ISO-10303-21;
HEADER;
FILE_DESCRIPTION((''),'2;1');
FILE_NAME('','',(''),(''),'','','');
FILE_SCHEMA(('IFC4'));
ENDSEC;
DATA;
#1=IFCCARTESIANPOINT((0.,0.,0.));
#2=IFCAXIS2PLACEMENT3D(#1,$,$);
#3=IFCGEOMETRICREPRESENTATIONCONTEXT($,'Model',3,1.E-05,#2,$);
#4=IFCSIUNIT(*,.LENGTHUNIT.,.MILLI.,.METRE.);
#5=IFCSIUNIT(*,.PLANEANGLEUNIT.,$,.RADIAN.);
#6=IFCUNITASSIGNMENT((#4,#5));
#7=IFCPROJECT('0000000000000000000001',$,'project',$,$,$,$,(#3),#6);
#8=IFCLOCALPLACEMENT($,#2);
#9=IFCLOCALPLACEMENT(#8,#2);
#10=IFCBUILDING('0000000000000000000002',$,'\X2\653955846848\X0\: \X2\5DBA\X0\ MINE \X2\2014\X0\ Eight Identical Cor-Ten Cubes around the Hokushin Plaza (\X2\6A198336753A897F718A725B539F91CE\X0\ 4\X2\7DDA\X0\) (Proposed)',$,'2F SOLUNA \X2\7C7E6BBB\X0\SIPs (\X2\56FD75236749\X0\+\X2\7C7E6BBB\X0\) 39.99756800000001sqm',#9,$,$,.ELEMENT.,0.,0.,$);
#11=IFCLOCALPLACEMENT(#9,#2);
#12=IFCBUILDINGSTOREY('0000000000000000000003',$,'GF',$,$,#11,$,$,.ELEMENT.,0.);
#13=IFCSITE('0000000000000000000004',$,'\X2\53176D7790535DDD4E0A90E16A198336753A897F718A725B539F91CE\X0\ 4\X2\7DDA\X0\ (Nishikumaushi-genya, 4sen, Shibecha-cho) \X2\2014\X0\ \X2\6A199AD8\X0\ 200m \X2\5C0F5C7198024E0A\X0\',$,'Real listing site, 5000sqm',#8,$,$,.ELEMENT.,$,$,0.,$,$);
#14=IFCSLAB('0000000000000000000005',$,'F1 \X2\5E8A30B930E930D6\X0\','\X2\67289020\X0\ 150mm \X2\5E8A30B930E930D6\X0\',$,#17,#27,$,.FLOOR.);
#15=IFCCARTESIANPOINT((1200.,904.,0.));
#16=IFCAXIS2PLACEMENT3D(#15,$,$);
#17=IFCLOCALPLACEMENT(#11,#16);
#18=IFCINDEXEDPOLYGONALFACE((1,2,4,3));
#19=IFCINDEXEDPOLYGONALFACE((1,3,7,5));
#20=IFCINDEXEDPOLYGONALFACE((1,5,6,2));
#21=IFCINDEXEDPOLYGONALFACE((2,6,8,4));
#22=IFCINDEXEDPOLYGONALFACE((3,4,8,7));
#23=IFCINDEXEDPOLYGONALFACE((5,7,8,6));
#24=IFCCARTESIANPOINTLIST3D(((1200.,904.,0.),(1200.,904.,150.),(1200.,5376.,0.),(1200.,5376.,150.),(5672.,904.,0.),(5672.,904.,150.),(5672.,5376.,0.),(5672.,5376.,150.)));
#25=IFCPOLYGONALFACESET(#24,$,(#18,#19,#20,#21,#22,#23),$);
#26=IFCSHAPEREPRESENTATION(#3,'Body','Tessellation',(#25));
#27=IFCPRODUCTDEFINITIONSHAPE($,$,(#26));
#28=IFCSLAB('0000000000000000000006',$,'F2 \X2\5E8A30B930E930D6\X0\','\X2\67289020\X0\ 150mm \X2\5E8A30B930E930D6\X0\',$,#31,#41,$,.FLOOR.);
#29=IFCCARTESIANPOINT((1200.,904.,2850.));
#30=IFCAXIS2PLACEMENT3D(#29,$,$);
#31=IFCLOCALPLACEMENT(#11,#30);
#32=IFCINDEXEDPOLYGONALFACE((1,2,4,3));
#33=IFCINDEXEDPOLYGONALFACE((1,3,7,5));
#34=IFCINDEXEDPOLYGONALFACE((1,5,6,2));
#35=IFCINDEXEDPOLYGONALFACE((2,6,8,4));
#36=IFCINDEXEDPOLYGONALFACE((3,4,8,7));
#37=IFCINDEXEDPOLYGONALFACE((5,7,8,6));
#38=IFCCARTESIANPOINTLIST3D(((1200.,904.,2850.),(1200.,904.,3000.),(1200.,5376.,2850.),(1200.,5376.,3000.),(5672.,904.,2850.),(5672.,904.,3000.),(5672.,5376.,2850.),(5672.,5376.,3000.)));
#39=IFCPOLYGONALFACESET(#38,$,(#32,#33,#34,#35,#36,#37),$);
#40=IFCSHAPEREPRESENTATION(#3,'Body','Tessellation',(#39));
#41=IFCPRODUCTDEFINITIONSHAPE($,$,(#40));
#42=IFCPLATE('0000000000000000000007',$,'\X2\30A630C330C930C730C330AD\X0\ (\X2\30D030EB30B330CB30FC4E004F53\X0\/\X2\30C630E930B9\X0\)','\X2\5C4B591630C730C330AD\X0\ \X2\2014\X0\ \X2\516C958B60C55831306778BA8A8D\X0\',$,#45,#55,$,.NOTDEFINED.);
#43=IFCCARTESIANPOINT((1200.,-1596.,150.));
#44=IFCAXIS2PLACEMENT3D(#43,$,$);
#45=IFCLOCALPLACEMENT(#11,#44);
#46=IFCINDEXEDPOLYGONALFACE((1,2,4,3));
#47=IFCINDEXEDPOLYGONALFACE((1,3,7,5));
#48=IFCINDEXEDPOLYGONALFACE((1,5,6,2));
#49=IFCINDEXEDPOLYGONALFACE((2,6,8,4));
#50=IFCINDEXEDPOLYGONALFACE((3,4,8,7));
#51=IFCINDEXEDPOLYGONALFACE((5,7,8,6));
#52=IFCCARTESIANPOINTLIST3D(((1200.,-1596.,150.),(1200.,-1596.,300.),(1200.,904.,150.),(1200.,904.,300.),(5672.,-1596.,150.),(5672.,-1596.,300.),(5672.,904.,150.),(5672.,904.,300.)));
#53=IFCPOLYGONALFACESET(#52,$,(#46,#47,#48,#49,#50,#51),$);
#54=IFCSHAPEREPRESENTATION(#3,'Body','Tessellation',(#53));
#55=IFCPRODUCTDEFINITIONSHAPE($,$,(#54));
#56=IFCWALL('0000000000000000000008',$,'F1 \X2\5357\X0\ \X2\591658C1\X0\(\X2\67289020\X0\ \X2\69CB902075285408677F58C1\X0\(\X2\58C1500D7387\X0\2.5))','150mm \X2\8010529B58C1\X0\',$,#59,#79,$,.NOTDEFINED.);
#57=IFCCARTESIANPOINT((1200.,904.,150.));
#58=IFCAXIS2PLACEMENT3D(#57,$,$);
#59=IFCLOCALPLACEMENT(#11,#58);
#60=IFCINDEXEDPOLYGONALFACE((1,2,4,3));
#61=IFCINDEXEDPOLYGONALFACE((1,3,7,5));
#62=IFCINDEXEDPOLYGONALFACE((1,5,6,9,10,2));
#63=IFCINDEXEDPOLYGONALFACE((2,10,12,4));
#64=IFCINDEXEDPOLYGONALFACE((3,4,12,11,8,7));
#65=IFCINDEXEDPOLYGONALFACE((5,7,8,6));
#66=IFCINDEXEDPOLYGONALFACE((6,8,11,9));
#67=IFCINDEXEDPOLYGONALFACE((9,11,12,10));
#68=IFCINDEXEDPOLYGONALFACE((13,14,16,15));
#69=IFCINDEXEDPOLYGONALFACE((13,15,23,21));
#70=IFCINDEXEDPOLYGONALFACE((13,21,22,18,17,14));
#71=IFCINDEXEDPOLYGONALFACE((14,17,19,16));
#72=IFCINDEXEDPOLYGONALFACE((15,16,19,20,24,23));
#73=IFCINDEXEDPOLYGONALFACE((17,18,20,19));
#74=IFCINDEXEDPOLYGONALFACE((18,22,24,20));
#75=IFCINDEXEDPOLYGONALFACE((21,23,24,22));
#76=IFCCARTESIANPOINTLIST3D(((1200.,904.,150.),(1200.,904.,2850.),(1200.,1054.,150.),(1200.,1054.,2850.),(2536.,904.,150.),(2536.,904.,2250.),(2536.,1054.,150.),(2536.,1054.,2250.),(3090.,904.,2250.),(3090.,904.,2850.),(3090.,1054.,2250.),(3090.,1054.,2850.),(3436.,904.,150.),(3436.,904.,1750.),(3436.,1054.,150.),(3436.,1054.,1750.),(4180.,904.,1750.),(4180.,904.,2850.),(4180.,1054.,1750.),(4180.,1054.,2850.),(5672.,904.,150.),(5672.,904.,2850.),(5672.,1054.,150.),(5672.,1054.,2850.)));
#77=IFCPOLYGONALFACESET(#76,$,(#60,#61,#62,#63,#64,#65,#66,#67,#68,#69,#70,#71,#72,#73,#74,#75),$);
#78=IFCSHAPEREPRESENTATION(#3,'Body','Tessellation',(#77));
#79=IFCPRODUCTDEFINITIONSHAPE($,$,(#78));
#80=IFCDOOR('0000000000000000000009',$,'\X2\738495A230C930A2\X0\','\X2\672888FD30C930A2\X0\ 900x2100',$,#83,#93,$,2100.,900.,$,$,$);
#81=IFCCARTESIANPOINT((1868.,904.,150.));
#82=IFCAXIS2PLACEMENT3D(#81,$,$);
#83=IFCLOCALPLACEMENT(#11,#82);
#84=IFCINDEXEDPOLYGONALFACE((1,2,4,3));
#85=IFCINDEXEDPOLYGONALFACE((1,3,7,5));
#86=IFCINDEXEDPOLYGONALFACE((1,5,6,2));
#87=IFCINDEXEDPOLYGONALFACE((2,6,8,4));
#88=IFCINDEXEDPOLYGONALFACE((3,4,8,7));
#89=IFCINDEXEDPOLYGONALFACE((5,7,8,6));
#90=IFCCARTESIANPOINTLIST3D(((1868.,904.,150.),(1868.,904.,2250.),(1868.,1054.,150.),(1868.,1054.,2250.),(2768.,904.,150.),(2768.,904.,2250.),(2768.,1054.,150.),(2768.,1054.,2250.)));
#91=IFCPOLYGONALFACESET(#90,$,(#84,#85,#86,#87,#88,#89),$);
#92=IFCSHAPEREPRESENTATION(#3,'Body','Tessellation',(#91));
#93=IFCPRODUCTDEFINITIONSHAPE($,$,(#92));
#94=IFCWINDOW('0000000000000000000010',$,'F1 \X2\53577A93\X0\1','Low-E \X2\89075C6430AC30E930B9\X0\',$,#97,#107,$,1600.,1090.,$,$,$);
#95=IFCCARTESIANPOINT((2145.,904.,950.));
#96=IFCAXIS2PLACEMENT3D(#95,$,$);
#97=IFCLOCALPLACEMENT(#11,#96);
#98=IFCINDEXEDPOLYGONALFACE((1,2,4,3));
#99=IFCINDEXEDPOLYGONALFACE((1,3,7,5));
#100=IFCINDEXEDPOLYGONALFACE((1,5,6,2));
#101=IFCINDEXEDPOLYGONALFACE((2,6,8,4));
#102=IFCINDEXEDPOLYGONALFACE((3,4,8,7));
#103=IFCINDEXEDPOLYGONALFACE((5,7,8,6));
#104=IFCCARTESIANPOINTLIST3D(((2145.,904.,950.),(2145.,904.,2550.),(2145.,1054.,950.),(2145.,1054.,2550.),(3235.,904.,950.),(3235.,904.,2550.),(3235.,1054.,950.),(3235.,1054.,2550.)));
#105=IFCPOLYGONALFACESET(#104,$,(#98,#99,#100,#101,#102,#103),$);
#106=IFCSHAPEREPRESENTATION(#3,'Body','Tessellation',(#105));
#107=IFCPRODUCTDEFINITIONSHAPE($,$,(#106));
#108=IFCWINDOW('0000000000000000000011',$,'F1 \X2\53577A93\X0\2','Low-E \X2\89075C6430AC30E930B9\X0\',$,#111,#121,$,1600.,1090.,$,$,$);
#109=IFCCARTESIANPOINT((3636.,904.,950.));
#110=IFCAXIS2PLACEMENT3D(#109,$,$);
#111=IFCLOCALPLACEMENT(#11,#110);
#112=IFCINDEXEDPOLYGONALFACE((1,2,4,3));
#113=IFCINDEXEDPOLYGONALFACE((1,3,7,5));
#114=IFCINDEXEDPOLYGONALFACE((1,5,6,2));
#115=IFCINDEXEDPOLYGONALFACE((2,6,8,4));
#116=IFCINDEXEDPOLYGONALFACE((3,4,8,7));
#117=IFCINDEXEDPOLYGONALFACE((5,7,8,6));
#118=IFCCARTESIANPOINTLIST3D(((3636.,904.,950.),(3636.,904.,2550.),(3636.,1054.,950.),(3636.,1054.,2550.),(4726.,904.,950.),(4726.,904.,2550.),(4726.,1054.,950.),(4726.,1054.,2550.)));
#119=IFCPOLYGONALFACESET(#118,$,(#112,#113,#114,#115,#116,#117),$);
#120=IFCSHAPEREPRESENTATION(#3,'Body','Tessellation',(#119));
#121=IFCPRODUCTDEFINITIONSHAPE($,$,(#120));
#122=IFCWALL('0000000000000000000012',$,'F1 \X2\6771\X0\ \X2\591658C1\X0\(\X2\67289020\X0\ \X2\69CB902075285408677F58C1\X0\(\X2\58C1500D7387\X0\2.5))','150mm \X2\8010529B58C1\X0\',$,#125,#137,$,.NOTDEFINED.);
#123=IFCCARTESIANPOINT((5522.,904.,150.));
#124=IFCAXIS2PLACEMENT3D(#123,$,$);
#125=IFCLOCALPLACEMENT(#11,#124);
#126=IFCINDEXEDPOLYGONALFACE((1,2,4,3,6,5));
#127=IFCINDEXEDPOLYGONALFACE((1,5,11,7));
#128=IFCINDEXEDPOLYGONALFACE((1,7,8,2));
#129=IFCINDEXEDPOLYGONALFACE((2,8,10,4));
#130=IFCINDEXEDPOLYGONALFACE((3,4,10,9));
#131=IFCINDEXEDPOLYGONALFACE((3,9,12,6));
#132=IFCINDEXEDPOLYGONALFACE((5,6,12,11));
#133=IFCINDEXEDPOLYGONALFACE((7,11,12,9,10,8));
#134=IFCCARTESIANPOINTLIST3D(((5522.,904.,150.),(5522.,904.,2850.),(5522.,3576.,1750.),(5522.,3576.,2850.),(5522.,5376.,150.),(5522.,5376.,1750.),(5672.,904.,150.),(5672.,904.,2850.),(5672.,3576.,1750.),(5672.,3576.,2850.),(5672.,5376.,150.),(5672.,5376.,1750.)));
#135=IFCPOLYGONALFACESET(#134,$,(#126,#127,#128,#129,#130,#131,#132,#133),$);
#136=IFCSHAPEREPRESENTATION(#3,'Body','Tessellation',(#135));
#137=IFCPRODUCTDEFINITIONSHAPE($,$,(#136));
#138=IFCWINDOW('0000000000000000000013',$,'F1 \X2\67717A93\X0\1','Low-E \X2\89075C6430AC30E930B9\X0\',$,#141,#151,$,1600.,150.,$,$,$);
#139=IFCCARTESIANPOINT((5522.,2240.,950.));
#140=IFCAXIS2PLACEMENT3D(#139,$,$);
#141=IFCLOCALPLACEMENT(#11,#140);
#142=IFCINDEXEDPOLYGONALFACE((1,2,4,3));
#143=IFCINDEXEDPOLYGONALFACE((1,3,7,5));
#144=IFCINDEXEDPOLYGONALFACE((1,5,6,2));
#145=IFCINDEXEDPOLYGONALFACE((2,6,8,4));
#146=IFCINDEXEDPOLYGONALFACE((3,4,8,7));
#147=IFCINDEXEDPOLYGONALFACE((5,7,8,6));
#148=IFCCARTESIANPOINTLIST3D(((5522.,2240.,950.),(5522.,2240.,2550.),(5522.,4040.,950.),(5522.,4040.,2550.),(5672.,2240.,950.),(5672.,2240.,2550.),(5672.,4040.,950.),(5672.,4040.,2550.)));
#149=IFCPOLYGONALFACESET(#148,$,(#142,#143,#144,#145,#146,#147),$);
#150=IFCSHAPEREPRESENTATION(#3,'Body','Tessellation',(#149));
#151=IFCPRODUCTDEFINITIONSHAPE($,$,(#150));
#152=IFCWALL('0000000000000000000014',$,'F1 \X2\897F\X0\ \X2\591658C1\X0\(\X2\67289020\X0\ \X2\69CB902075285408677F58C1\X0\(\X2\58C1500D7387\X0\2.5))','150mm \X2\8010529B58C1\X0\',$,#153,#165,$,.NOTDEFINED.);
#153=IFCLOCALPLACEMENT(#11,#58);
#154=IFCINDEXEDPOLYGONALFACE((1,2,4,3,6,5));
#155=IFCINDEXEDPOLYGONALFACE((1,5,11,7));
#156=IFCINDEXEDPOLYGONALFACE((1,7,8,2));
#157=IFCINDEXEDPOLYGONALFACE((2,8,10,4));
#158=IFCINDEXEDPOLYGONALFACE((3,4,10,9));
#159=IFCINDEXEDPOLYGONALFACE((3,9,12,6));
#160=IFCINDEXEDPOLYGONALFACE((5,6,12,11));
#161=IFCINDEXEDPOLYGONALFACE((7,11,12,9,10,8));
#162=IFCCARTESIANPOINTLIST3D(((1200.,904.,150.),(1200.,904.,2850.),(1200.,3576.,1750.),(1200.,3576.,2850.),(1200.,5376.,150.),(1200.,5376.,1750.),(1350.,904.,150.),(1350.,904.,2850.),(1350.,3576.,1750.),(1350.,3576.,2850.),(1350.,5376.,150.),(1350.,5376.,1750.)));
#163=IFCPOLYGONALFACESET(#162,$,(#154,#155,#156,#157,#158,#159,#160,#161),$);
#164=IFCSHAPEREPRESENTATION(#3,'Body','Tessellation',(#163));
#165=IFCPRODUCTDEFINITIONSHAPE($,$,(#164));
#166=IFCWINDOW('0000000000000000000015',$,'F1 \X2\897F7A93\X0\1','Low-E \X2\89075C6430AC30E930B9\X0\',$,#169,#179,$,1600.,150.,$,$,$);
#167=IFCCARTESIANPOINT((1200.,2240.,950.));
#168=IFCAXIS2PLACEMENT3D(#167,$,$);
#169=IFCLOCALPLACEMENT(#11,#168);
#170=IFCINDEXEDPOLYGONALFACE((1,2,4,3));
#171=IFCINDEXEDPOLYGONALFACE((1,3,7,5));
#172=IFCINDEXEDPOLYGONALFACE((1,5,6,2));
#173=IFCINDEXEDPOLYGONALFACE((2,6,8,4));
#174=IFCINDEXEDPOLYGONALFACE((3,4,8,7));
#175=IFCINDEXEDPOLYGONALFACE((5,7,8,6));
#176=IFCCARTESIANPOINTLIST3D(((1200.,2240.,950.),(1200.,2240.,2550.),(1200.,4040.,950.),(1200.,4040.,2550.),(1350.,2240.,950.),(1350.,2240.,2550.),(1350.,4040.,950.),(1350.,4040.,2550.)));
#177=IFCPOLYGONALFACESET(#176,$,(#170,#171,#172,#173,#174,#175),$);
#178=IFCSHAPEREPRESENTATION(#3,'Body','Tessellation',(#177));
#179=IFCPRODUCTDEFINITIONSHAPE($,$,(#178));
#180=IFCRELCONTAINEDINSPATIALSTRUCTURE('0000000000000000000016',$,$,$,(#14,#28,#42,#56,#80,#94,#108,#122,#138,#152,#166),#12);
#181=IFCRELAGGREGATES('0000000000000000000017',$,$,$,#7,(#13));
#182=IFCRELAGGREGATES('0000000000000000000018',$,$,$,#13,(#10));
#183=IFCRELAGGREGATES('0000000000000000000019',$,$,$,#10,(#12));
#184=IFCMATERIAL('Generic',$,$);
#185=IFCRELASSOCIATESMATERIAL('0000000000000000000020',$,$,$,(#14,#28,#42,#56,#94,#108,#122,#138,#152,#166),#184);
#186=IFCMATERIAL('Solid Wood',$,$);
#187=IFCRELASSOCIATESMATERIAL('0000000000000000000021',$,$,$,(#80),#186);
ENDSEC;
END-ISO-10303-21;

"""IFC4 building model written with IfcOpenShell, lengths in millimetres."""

from ifc_helpers import new_model, si_unit, frame, frame_2d, origin, place, context, project, spatial, rectangle, extrude, material, element, fill, save


model = new_model("IFC4")

# Units and contexts
model_context = context("Model", 3, precision=1e-05, world=origin())
ifc_project = project(units=[si_unit("LENGTHUNIT", "METRE", prefix="MILLI"), si_unit("PLANEANGLEUNIT", "RADIAN")], contexts=[model_context])

# Site, building, storey
site_placement = place(None, origin())
site = spatial("IfcSite", under=ifc_project, at=site_placement, Name="北海道川上郡標茶町西熊牛原野 4線 (Nishikumaushi-genya, 4sen, Shibecha-cho) — 標高 200m 小山頂上", ObjectType="Real listing site, 5000sqm", CompositionType="ELEMENT", RefElevation=0.0)
building_placement = place(site_placement, origin())
building = spatial("IfcBuilding", under=site, at=building_placement, Name="改善案: 嶺 MINE — Eight Identical Cor-Ten Cubes around the Hokushin Plaza (標茶町西熊牛原野 4線) (Proposed)", ObjectType="2F SOLUNA 籾殻SIPs (国産杉+籾殻) 39.99756800000001sqm", CompositionType="ELEMENT", ElevationOfRefHeight=0.0, ElevationOfTerrain=0.0)
storey_placement = place(building_placement, origin())
storey = spatial("IfcBuildingStorey", under=building, at=storey_placement, Name="GF", CompositionType="ELEMENT", Elevation=0.0)

# Slabs
ifc_material_1 = material(Name="Generic")
slab_1_placement = place(storey_placement, frame((1200.0, 904.0, 0.0)))
element("IfcSlab", 1, at=slab_1_placement, inside=storey, material=ifc_material_1, Name="F1 床スラブ", Description="木造 150mm 床スラブ", PredefinedType="FLOOR", context=model_context, shape_type="SweptSolid", body=[
    extrude(rectangle(XDim=4472.0, YDim=4472.0, at=frame_2d((2236.0, 2236.0))), frame((1200.0, 904.0, 0.0)), (0.0, 0.0, 1.0), 150.0),
])
slab_2_placement = place(storey_placement, frame((1200.0, 904.0, 2850.0)))
element("IfcSlab", 2, at=slab_2_placement, inside=storey, material=ifc_material_1, Name="F2 床スラブ", Description="木造 150mm 床スラブ", PredefinedType="FLOOR", context=model_context, shape_type="SweptSolid", body=[
    extrude(rectangle(XDim=4472.0, YDim=4472.0, at=frame_2d((2236.0, 2236.0))), frame((1200.0, 904.0, 2850.0)), (0.0, 0.0, 1.0), 150.0),
])

# Plate
plate_placement = place(storey_placement, frame((1200.0, -1596.0, 150.0)))
element("IfcPlate", 3, at=plate_placement, inside=storey, material=ifc_material_1, Name="ウッドデッキ (バルコニー一体/テラス)", Description="屋外デッキ — 公開情報で確認", PredefinedType="NOTDEFINED", context=model_context, shape_type="SweptSolid", body=[
    extrude(rectangle(XDim=4472.0, YDim=2500.0, at=frame_2d((2236.0, 1250.0))), frame((1200.0, -1596.0, 150.0)), (0.0, 0.0, 1.0), 150.0),
])

# Wall, openings, door, windows
wall_1_placement = place(storey_placement, frame((1200.0, 904.0, 150.0)))
wall_1 = element("IfcWall", 4, at=wall_1_placement, inside=storey, material=ifc_material_1, Name="F1 南 外壁(木造 構造用合板壁(壁倍率2.5))", Description="150mm 耐力壁", PredefinedType="NOTDEFINED", context=model_context, shape_type="SweptSolid", body=[
    extrude(rectangle(XDim=4472.0, YDim=150.0, at=frame_2d((2236.0, 75.0))), frame((1200.0, 904.0, 150.0)), (0.0, 0.0, 1.0), 2700.0),
])
opening_1_placement = place(storey_placement, frame((1868.0, 904.0, 150.0)))
opening_1 = element("IfcOpeningElement", 5, at=opening_1_placement, cuts=wall_1, PredefinedType="NOTDEFINED", context=model_context, shape_type="SweptSolid", body=[
    extrude(rectangle(XDim=900.0, YDim=150.0, at=frame_2d((450.0, 75.0))), frame((1868.0, 904.0, 150.0)), (0.0, 0.0, 1.0), 2100.0),
])
opening_2_placement = place(storey_placement, frame((2145.0, 904.0, 950.0)))
opening_2 = element("IfcOpeningElement", 6, at=opening_2_placement, cuts=wall_1, PredefinedType="NOTDEFINED", context=model_context, shape_type="SweptSolid", body=[
    extrude(rectangle(XDim=1090.0, YDim=150.0, at=frame_2d((545.0, 75.0))), frame((2145.0, 904.0, 950.0)), (0.0, 0.0, 1.0), 1600.0),
])
opening_3_placement = place(storey_placement, frame((3636.0, 904.0, 950.0)))
opening_3 = element("IfcOpeningElement", 7, at=opening_3_placement, cuts=wall_1, PredefinedType="NOTDEFINED", context=model_context, shape_type="SweptSolid", body=[
    extrude(rectangle(XDim=1090.0, YDim=150.0, at=frame_2d((545.0, 75.0))), frame((3636.0, 904.0, 950.0)), (0.0, 0.0, 1.0), 1600.0),
])
ifc_material_2 = material(Name="Solid Wood")
door_placement = place(storey_placement, frame((1868.0, 904.0, 150.0)))
door = element("IfcDoor", 8, at=door_placement, inside=storey, material=ifc_material_2, Name="玄関ドア", Description="木製ドア 900x2100", OverallHeight=2100.0, OverallWidth=900.0, context=model_context, shape_type="SweptSolid", body=[
    extrude(rectangle(XDim=900.0, YDim=150.0, at=frame_2d((450.0, 75.0))), frame((1868.0, 904.0, 150.0)), (0.0, 0.0, 1.0), 2100.0),
])
fill(opening_1, door)
window_1_placement = place(storey_placement, frame((2145.0, 904.0, 950.0)))
window_1 = element("IfcWindow", 9, at=window_1_placement, inside=storey, material=ifc_material_1, Name="F1 南窓1", Description="Low-E 複層ガラス", OverallHeight=1600.0, OverallWidth=1090.0, context=model_context, shape_type="SweptSolid", body=[
    extrude(rectangle(XDim=1090.0, YDim=150.0, at=frame_2d((545.0, 75.0))), frame((2145.0, 904.0, 950.0)), (0.0, 0.0, 1.0), 1600.0),
])
fill(opening_2, window_1)
window_2_placement = place(storey_placement, frame((3636.0, 904.0, 950.0)))
window_2 = element("IfcWindow", 10, at=window_2_placement, inside=storey, material=ifc_material_1, Name="F1 南窓2", Description="Low-E 複層ガラス", OverallHeight=1600.0, OverallWidth=1090.0, context=model_context, shape_type="SweptSolid", body=[
    extrude(rectangle(XDim=1090.0, YDim=150.0, at=frame_2d((545.0, 75.0))), frame((3636.0, 904.0, 950.0)), (0.0, 0.0, 1.0), 1600.0),
])
fill(opening_3, window_2)

# Walls, openings, windows
wall_2_placement = place(storey_placement, frame((5522.0, 904.0, 150.0)))
wall_2 = element("IfcWall", 11, at=wall_2_placement, inside=storey, material=ifc_material_1, Name="F1 東 外壁(木造 構造用合板壁(壁倍率2.5))", Description="150mm 耐力壁", PredefinedType="NOTDEFINED", context=model_context, shape_type="SweptSolid", body=[
    extrude(rectangle(XDim=150.0, YDim=4472.0, at=frame_2d((75.0, 2236.0))), frame((5522.0, 904.0, 150.0)), (0.0, 0.0, 1.0), 2700.0),
])
opening_4_placement = place(storey_placement, frame((5522.0, 2240.0, 950.0)))
opening_4 = element("IfcOpeningElement", 12, at=opening_4_placement, cuts=wall_2, PredefinedType="NOTDEFINED", context=model_context, shape_type="SweptSolid", body=[
    extrude(rectangle(XDim=150.0, YDim=1800.0, at=frame_2d((75.0, 900.0))), frame((5522.0, 2240.0, 950.0)), (0.0, 0.0, 1.0), 1600.0),
])
window_3_placement = place(storey_placement, frame((5522.0, 2240.0, 950.0)))
window_3 = element("IfcWindow", 13, at=window_3_placement, inside=storey, material=ifc_material_1, Name="F1 東窓1", Description="Low-E 複層ガラス", OverallHeight=1600.0, OverallWidth=150.0, context=model_context, shape_type="SweptSolid", body=[
    extrude(rectangle(XDim=150.0, YDim=1800.0, at=frame_2d((75.0, 900.0))), frame((5522.0, 2240.0, 950.0)), (0.0, 0.0, 1.0), 1600.0),
])
fill(opening_4, window_3)
wall_3_placement = place(storey_placement, frame((1200.0, 904.0, 150.0)))
wall_3 = element("IfcWall", 14, at=wall_3_placement, inside=storey, material=ifc_material_1, Name="F1 西 外壁(木造 構造用合板壁(壁倍率2.5))", Description="150mm 耐力壁", PredefinedType="NOTDEFINED", context=model_context, shape_type="SweptSolid", body=[
    extrude(rectangle(XDim=150.0, YDim=4472.0, at=frame_2d((75.0, 2236.0))), frame((1200.0, 904.0, 150.0)), (0.0, 0.0, 1.0), 2700.0),
])
opening_5_placement = place(storey_placement, frame((1200.0, 2240.0, 950.0)))
opening_5 = element("IfcOpeningElement", 15, at=opening_5_placement, cuts=wall_3, PredefinedType="NOTDEFINED", context=model_context, shape_type="SweptSolid", body=[
    extrude(rectangle(XDim=150.0, YDim=1800.0, at=frame_2d((75.0, 900.0))), frame((1200.0, 2240.0, 950.0)), (0.0, 0.0, 1.0), 1600.0),
])
window_4_placement = place(storey_placement, frame((1200.0, 2240.0, 950.0)))
window_4 = element("IfcWindow", 16, at=window_4_placement, inside=storey, material=ifc_material_1, Name="F1 西窓1", Description="Low-E 複層ガラス", OverallHeight=1600.0, OverallWidth=150.0, context=model_context, shape_type="SweptSolid", body=[
    extrude(rectangle(XDim=150.0, YDim=1800.0, at=frame_2d((75.0, 900.0))), frame((1200.0, 2240.0, 950.0)), (0.0, 0.0, 1.0), 1600.0),
])
fill(opening_5, window_4)

save(model, "model.ifc")
